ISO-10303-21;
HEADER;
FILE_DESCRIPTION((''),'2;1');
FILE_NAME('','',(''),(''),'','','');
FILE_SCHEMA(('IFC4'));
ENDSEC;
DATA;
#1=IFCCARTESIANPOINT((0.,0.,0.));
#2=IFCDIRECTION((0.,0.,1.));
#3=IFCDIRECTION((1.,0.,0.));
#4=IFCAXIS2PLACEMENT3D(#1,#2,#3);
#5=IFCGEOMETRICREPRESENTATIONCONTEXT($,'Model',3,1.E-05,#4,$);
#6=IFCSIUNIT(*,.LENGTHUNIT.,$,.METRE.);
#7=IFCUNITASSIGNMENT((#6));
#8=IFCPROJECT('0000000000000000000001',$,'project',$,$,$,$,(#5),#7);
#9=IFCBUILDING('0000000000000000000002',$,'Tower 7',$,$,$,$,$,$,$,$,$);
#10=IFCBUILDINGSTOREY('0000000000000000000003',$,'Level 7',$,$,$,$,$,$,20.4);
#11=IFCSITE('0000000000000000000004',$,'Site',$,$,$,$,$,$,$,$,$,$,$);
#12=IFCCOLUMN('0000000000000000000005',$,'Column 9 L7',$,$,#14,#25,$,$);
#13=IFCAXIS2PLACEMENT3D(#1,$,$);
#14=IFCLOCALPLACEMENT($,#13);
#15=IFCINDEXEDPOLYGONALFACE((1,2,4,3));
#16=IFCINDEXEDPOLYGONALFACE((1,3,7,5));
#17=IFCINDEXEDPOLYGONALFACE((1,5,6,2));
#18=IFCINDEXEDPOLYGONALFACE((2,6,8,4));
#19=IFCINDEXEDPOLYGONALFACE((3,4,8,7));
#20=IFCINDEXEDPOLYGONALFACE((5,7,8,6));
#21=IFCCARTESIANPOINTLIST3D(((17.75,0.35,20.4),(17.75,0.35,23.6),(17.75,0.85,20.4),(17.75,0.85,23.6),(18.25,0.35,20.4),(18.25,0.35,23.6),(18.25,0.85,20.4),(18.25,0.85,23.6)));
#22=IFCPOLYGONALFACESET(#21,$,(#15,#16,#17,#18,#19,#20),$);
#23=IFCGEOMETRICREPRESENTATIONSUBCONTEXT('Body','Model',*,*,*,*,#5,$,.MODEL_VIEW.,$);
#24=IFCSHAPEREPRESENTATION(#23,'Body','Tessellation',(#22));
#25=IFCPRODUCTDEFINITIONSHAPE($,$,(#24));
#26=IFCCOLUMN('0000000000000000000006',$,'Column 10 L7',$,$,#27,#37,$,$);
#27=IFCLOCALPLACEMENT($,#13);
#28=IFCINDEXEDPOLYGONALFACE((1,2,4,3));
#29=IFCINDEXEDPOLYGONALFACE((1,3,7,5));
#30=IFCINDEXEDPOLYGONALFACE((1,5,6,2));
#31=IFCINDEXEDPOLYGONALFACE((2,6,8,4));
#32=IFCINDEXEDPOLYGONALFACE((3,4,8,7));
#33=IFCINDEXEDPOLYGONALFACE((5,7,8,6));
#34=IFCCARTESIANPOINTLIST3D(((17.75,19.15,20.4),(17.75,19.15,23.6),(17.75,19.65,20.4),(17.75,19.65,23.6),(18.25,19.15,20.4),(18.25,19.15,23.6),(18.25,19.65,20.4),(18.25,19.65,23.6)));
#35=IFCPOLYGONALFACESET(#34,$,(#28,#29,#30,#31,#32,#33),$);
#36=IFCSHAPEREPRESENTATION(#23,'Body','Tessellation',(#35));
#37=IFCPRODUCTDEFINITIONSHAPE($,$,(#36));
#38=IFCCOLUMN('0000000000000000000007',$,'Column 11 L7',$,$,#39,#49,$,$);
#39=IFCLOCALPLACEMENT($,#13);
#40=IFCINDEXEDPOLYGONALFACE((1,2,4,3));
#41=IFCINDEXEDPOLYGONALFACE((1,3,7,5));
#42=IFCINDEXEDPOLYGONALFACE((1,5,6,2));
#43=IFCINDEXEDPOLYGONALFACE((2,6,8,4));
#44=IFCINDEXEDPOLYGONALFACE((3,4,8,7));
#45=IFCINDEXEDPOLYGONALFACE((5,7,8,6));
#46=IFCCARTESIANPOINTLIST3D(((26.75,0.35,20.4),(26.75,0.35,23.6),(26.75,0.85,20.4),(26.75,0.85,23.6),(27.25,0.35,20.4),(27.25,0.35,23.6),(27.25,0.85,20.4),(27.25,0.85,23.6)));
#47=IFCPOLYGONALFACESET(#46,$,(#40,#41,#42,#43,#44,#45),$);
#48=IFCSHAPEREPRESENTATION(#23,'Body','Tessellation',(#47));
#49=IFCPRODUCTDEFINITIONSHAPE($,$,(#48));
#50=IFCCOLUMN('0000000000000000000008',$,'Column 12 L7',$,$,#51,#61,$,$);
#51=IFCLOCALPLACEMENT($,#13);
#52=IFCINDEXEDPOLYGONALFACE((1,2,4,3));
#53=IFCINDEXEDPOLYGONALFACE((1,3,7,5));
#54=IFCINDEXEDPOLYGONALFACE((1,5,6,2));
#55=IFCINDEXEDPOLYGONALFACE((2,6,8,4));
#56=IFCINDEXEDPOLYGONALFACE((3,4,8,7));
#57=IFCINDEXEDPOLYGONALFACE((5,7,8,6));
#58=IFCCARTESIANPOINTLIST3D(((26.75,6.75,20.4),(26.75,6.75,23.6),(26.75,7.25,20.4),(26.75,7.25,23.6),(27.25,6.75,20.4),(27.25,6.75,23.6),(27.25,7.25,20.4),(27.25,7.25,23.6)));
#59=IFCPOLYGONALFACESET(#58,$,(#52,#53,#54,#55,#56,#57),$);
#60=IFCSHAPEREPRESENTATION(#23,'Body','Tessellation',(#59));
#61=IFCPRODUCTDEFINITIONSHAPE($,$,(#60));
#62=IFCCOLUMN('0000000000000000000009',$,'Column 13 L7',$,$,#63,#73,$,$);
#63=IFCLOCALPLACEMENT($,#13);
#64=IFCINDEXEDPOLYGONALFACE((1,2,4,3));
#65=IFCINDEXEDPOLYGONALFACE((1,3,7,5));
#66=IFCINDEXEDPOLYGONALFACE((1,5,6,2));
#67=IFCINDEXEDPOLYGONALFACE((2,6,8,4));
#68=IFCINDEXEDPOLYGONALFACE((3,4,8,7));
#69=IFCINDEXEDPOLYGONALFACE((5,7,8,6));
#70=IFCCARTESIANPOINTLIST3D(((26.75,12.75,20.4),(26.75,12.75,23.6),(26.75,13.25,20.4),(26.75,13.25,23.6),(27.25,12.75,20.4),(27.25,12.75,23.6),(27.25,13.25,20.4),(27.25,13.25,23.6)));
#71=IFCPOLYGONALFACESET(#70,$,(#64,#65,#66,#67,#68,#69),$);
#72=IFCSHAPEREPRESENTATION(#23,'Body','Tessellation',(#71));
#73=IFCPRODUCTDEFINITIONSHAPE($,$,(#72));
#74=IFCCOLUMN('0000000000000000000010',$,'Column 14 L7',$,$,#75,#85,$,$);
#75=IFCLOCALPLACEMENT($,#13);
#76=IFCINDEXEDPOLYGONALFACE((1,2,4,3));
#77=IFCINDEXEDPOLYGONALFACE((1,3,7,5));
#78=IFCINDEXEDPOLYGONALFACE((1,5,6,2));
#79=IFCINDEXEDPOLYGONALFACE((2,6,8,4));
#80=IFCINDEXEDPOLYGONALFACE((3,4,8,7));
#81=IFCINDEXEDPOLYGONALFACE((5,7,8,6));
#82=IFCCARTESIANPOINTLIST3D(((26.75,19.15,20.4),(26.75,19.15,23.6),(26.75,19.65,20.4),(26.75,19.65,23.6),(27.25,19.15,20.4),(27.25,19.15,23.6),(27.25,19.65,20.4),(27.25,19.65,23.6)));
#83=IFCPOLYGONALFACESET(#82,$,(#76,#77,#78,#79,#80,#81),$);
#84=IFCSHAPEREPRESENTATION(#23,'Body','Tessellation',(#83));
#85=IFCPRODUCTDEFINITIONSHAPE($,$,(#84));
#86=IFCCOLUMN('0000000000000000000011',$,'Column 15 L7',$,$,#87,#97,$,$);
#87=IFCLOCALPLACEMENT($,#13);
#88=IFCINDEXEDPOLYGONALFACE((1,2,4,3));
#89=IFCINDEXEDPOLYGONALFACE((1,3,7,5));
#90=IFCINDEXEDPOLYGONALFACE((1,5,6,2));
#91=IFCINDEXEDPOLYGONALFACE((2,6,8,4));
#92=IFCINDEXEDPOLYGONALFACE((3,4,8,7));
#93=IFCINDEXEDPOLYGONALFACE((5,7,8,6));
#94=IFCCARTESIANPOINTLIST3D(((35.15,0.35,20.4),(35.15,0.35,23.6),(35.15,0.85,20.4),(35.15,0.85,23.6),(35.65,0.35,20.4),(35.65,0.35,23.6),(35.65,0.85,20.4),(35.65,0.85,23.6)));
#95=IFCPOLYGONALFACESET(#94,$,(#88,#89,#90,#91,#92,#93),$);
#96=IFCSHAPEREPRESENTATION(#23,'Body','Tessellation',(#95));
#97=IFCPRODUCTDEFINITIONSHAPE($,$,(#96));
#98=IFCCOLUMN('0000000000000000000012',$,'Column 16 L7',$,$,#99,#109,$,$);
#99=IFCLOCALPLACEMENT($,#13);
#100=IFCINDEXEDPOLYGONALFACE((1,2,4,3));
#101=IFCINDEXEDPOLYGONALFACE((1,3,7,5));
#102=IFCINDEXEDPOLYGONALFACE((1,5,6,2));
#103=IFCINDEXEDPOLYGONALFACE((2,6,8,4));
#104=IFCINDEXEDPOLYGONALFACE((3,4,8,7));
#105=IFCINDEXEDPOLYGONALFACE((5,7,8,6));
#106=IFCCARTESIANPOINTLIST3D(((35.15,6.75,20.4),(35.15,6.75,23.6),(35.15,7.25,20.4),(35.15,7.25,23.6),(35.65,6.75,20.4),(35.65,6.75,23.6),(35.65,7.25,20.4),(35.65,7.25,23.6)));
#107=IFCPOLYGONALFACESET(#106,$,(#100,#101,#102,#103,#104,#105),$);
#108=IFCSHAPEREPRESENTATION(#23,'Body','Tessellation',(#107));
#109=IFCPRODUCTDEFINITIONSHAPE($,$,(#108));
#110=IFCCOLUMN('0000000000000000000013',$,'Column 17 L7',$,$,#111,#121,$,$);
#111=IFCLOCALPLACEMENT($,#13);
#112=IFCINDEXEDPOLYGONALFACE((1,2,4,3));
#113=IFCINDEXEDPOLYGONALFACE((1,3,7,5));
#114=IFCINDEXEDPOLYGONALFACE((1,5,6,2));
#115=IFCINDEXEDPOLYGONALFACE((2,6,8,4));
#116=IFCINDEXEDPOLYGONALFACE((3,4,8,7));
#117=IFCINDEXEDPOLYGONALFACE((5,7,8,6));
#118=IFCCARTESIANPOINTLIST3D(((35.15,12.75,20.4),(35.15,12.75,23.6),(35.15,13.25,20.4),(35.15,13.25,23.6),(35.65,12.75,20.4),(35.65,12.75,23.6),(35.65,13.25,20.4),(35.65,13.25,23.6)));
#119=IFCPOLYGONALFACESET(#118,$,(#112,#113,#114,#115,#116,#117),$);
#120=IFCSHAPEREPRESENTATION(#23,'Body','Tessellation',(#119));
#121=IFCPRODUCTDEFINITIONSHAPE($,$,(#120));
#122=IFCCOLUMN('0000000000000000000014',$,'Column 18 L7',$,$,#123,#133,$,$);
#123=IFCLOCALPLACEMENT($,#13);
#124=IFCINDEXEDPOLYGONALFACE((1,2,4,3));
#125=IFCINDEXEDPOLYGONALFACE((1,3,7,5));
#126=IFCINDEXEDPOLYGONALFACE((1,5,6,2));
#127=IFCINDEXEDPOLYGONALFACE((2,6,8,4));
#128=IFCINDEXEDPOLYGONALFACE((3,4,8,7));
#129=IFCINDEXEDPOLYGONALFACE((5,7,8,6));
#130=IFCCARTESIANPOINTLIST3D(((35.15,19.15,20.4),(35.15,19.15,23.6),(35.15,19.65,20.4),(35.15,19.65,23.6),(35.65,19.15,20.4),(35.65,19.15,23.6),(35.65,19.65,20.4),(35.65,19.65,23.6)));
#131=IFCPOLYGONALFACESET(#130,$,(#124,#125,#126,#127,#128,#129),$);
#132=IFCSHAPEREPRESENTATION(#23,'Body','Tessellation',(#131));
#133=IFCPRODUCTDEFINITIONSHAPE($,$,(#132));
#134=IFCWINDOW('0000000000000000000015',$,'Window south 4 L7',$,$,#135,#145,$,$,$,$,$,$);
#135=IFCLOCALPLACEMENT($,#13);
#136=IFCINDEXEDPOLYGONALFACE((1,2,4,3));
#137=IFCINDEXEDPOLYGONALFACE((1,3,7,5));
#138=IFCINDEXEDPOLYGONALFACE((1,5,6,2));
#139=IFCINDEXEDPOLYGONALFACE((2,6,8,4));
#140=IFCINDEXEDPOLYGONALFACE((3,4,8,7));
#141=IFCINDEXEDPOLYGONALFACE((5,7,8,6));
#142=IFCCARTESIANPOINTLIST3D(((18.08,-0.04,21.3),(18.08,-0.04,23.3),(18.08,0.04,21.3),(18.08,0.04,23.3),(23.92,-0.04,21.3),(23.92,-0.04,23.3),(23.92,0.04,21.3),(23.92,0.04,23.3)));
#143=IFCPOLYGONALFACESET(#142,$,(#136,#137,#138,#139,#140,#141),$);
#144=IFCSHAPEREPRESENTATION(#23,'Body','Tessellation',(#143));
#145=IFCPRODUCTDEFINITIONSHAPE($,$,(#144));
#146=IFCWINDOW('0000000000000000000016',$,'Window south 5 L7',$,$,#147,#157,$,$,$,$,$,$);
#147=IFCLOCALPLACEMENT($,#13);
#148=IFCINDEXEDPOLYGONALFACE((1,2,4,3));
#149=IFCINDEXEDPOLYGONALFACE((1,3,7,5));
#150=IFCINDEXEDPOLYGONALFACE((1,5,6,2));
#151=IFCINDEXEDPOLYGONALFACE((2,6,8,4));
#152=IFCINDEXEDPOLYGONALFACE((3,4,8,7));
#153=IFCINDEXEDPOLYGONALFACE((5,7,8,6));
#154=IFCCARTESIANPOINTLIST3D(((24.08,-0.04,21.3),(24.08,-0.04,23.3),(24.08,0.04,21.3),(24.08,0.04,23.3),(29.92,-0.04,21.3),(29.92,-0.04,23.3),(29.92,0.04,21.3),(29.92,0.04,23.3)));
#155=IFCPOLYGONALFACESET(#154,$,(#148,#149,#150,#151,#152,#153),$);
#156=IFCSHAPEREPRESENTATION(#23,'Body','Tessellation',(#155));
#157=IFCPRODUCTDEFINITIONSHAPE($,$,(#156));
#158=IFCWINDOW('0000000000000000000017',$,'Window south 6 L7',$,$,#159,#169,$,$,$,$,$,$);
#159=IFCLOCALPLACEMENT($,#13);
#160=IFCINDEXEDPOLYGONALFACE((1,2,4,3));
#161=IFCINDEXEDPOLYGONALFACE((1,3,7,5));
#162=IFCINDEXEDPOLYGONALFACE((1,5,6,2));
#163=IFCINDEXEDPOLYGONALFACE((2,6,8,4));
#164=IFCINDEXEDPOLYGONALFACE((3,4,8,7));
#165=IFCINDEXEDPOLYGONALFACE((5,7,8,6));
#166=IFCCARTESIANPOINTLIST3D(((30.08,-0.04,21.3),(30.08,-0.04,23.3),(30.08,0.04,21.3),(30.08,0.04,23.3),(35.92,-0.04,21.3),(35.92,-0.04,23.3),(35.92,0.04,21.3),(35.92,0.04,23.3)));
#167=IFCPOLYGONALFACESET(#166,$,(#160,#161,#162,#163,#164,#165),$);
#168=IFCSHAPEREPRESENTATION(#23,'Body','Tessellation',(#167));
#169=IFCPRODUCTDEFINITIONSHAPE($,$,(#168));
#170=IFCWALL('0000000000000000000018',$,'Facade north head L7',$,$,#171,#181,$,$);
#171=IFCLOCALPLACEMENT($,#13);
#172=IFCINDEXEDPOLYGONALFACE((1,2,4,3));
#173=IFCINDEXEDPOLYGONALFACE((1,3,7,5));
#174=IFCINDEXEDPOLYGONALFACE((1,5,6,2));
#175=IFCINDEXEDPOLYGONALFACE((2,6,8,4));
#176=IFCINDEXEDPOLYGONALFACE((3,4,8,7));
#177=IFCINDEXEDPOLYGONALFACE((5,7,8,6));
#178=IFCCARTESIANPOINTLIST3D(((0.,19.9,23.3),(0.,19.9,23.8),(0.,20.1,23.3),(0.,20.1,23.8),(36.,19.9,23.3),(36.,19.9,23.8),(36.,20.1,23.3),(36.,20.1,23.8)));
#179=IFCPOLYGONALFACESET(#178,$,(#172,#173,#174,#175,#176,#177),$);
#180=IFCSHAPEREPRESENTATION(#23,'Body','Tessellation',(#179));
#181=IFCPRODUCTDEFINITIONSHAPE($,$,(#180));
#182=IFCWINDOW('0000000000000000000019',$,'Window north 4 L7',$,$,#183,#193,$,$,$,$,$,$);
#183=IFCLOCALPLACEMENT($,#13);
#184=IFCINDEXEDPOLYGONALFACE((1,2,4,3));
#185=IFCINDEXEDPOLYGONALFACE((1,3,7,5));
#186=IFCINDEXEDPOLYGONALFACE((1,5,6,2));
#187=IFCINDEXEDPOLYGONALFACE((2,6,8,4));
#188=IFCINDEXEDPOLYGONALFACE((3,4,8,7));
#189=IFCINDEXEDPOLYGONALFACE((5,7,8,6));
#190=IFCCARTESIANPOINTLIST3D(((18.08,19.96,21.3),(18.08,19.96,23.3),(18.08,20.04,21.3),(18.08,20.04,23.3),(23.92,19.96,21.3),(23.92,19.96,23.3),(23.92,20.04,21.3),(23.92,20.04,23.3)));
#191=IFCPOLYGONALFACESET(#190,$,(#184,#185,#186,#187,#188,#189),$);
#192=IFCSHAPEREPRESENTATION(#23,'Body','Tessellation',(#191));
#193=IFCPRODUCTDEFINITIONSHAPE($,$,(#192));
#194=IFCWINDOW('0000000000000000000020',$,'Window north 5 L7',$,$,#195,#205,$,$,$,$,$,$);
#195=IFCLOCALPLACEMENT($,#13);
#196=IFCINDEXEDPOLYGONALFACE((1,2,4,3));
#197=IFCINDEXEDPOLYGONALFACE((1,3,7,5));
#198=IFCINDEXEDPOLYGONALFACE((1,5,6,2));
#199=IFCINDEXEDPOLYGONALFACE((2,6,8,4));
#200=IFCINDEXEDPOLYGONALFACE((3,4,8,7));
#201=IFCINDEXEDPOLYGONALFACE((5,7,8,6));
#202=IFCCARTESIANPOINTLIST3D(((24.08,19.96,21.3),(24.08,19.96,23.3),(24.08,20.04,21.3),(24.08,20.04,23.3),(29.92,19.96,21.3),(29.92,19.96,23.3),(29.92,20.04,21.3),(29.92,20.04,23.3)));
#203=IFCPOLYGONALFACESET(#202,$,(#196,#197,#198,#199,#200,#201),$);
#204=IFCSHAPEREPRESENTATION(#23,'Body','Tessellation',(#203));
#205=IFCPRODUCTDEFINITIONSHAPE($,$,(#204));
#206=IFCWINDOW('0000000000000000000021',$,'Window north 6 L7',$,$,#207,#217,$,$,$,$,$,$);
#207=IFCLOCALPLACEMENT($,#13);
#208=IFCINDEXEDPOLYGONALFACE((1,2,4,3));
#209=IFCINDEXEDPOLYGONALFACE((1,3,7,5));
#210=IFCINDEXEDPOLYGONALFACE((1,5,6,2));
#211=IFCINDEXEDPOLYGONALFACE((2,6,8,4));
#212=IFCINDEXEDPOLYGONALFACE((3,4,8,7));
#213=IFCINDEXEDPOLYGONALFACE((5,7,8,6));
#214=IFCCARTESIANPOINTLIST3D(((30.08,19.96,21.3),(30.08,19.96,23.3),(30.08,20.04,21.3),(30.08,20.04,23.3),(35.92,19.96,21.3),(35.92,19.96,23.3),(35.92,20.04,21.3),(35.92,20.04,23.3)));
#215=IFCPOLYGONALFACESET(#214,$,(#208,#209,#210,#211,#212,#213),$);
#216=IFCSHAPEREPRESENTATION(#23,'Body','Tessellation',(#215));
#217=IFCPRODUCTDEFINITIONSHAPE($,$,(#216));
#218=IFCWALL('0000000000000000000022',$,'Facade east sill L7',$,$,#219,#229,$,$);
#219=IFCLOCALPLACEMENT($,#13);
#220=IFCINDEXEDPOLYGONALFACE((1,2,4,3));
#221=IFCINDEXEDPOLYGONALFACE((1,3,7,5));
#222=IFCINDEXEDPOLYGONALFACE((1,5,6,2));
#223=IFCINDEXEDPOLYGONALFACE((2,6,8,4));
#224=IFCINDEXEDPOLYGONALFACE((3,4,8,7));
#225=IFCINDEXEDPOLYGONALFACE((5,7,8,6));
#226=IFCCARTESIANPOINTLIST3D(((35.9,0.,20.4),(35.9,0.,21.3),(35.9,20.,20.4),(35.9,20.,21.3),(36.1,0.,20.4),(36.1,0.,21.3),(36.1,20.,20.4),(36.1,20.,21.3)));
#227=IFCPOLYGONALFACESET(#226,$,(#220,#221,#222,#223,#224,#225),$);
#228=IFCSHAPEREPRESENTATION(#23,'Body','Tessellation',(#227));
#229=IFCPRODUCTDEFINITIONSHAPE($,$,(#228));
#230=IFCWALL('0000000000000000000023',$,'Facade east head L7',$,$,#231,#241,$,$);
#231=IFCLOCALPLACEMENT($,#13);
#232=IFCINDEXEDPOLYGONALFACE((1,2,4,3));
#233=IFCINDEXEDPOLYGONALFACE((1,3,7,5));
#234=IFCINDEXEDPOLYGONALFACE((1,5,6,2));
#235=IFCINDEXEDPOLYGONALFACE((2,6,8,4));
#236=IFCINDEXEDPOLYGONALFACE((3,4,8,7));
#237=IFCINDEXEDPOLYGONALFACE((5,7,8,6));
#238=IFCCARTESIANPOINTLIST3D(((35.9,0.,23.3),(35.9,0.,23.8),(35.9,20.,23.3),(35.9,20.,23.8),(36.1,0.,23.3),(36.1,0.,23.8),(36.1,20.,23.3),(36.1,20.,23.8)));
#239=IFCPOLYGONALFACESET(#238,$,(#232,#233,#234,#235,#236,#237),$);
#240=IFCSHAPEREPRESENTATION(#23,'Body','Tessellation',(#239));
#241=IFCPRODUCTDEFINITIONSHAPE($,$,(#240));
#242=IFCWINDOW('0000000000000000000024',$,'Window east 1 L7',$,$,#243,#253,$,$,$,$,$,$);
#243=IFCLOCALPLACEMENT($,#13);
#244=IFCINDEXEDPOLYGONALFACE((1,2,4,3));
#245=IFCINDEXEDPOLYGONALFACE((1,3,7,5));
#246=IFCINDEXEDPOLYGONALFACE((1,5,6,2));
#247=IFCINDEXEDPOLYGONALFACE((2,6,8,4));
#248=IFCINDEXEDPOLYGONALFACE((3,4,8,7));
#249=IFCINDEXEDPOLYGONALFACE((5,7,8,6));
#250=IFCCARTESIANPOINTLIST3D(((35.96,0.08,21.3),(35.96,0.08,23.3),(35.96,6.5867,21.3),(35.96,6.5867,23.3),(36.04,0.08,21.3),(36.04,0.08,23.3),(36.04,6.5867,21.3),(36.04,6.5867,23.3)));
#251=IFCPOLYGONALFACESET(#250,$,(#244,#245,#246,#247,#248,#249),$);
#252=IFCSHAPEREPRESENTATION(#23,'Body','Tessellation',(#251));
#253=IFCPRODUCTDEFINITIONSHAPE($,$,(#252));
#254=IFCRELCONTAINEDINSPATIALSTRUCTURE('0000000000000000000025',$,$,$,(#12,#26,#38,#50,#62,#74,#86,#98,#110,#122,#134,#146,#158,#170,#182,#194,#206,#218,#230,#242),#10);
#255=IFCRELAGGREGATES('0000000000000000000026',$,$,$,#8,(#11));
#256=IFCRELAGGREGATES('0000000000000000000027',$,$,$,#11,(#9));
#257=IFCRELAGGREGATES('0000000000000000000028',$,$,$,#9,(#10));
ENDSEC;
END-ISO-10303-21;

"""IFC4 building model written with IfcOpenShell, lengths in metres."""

from ifc_helpers import new_model, si_unit, frame, origin, origin_with_axes, origin_2d, place, context, subcontext, project, spatial, rectangle, extrude, element, save


model = new_model("IFC4")

# Units and contexts
model_context = context("Model", 3, precision=1e-05, world=origin_with_axes())
body_context = subcontext(model_context, "Body", "Model", "MODEL_VIEW")
ifc_project = project(units=[si_unit("LENGTHUNIT", "METRE")], contexts=[model_context])

# Site, building, storey
site = spatial("IfcSite", under=ifc_project, Name="Site")
building = spatial("IfcBuilding", under=site, Name="Tower 7")
storey = spatial("IfcBuildingStorey", under=building, Name="Level 7", Elevation=20.4)

# Columns
for number, where, z_axis, x_axis, name in (
    (1, (18.0, 0.6, 20.4), (0.0, 0.0, 1.0), (1.0, 0.0, 0.0), "Column 9 L7"),
    (2, (18.0, 19.4, 20.4), (0.0, 0.0, 1.0), (1.0, 0.0, 0.0), "Column 10 L7"),
    (3, (27.0, 0.6, 20.4), (0.0, 0.0, 1.0), (1.0, 0.0, 0.0), "Column 11 L7"),
    (4, (27.0, 7.0, 20.4), (0.0, 0.0, 1.0), (1.0, 0.0, 0.0), "Column 12 L7"),
    (5, (27.0, 13.0, 20.4), (0.0, 0.0, 1.0), (1.0, 0.0, 0.0), "Column 13 L7"),
    (6, (27.0, 19.4, 20.4), (0.0, 0.0, 1.0), (1.0, 0.0, 0.0), "Column 14 L7"),
    (7, (35.4, 0.6, 20.4), (0.0, 0.0, 1.0), (1.0, 0.0, 0.0), "Column 15 L7"),
    (8, (35.4, 7.0, 20.4), (0.0, 0.0, 1.0), (1.0, 0.0, 0.0), "Column 16 L7"),
    (9, (35.4, 13.0, 20.4), (0.0, 0.0, 1.0), (1.0, 0.0, 0.0), "Column 17 L7"),
    (10, (35.4, 19.4, 20.4), (0.0, 0.0, 1.0), (1.0, 0.0, 0.0), "Column 18 L7"),
):
    element("IfcColumn", number, at=place(None, frame(where, z_axis=z_axis, x_axis=x_axis)), inside=storey, Name=name, context=body_context, shape_type="SweptSolid", body=[
        extrude(rectangle(XDim=0.5, YDim=0.5, at=origin_2d()), origin(), (0.0, 0.0, 1.0), 3.2),
    ])

# Windows
for number, where, z_axis, x_axis, name in (
    (11, (21.0, 0.0, 21.3), (0.0, 0.0, 1.0), (1.0, 0.0, 0.0), "Window south 4 L7"),
    (12, (27.0, 0.0, 21.3), (0.0, 0.0, 1.0), (1.0, 0.0, 0.0), "Window south 5 L7"),
    (13, (33.0, 0.0, 21.3), (0.0, 0.0, 1.0), (1.0, 0.0, 0.0), "Window south 6 L7"),
):
    element("IfcWindow", number, at=place(None, frame(where, z_axis=z_axis, x_axis=x_axis)), inside=storey, Name=name, context=body_context, shape_type="SweptSolid", body=[
        extrude(rectangle(XDim=5.84, YDim=0.08, at=origin_2d()), origin(), (0.0, 0.0, 1.0), 2.0),
    ])

# Wall
wall_1_placement = place(None, frame((18.0, 20.0, 23.3), z_axis=(0.0, 0.0, 1.0), x_axis=(1.0, 0.0, 0.0)))
element("IfcWall", 14, at=wall_1_placement, inside=storey, Name="Facade north head L7", context=body_context, shape_type="SweptSolid", body=[
    extrude(rectangle(XDim=36.0, YDim=0.2, at=origin_2d()), origin(), (0.0, 0.0, 1.0), 0.5),
])

# Windows
for number, where, z_axis, x_axis, name in (
    (15, (21.0, 20.0, 21.3), (0.0, 0.0, 1.0), (1.0, 0.0, 0.0), "Window north 4 L7"),
    (16, (27.0, 20.0, 21.3), (0.0, 0.0, 1.0), (1.0, 0.0, 0.0), "Window north 5 L7"),
    (17, (33.0, 20.0, 21.3), (0.0, 0.0, 1.0), (1.0, 0.0, 0.0), "Window north 6 L7"),
):
    element("IfcWindow", number, at=place(None, frame(where, z_axis=z_axis, x_axis=x_axis)), inside=storey, Name=name, context=body_context, shape_type="SweptSolid", body=[
        extrude(rectangle(XDim=5.84, YDim=0.08, at=origin_2d()), origin(), (0.0, 0.0, 1.0), 2.0),
    ])

# Walls
wall_2_placement = place(None, frame((36.0, 10.0, 20.4), z_axis=(0.0, 0.0, 1.0), x_axis=(1.0, 0.0, 0.0)))
element("IfcWall", 18, at=wall_2_placement, inside=storey, Name="Facade east sill L7", context=body_context, shape_type="SweptSolid", body=[
    extrude(rectangle(XDim=0.2, YDim=20.0, at=origin_2d()), origin(), (0.0, 0.0, 1.0), 0.9),
])
wall_3_placement = place(None, frame((36.0, 10.0, 23.3), z_axis=(0.0, 0.0, 1.0), x_axis=(1.0, 0.0, 0.0)))
element("IfcWall", 19, at=wall_3_placement, inside=storey, Name="Facade east head L7", context=body_context, shape_type="SweptSolid", body=[
    extrude(rectangle(XDim=0.2, YDim=20.0, at=origin_2d()), origin(), (0.0, 0.0, 1.0), 0.5),
])

# Window
for number, where, z_axis, x_axis, name in (
    (20, (36.0, 3.3333, 21.3), (0.0, 0.0, 1.0), (1.0, 0.0, 0.0), "Window east 1 L7"),
):
    element("IfcWindow", number, at=place(None, frame(where, z_axis=z_axis, x_axis=x_axis)), inside=storey, Name=name, context=body_context, shape_type="SweptSolid", body=[
        extrude(rectangle(XDim=0.08, YDim=6.5067, at=origin_2d()), origin(), (0.0, 0.0, 1.0), 2.0),
    ])

save(model, "model.ifc")
